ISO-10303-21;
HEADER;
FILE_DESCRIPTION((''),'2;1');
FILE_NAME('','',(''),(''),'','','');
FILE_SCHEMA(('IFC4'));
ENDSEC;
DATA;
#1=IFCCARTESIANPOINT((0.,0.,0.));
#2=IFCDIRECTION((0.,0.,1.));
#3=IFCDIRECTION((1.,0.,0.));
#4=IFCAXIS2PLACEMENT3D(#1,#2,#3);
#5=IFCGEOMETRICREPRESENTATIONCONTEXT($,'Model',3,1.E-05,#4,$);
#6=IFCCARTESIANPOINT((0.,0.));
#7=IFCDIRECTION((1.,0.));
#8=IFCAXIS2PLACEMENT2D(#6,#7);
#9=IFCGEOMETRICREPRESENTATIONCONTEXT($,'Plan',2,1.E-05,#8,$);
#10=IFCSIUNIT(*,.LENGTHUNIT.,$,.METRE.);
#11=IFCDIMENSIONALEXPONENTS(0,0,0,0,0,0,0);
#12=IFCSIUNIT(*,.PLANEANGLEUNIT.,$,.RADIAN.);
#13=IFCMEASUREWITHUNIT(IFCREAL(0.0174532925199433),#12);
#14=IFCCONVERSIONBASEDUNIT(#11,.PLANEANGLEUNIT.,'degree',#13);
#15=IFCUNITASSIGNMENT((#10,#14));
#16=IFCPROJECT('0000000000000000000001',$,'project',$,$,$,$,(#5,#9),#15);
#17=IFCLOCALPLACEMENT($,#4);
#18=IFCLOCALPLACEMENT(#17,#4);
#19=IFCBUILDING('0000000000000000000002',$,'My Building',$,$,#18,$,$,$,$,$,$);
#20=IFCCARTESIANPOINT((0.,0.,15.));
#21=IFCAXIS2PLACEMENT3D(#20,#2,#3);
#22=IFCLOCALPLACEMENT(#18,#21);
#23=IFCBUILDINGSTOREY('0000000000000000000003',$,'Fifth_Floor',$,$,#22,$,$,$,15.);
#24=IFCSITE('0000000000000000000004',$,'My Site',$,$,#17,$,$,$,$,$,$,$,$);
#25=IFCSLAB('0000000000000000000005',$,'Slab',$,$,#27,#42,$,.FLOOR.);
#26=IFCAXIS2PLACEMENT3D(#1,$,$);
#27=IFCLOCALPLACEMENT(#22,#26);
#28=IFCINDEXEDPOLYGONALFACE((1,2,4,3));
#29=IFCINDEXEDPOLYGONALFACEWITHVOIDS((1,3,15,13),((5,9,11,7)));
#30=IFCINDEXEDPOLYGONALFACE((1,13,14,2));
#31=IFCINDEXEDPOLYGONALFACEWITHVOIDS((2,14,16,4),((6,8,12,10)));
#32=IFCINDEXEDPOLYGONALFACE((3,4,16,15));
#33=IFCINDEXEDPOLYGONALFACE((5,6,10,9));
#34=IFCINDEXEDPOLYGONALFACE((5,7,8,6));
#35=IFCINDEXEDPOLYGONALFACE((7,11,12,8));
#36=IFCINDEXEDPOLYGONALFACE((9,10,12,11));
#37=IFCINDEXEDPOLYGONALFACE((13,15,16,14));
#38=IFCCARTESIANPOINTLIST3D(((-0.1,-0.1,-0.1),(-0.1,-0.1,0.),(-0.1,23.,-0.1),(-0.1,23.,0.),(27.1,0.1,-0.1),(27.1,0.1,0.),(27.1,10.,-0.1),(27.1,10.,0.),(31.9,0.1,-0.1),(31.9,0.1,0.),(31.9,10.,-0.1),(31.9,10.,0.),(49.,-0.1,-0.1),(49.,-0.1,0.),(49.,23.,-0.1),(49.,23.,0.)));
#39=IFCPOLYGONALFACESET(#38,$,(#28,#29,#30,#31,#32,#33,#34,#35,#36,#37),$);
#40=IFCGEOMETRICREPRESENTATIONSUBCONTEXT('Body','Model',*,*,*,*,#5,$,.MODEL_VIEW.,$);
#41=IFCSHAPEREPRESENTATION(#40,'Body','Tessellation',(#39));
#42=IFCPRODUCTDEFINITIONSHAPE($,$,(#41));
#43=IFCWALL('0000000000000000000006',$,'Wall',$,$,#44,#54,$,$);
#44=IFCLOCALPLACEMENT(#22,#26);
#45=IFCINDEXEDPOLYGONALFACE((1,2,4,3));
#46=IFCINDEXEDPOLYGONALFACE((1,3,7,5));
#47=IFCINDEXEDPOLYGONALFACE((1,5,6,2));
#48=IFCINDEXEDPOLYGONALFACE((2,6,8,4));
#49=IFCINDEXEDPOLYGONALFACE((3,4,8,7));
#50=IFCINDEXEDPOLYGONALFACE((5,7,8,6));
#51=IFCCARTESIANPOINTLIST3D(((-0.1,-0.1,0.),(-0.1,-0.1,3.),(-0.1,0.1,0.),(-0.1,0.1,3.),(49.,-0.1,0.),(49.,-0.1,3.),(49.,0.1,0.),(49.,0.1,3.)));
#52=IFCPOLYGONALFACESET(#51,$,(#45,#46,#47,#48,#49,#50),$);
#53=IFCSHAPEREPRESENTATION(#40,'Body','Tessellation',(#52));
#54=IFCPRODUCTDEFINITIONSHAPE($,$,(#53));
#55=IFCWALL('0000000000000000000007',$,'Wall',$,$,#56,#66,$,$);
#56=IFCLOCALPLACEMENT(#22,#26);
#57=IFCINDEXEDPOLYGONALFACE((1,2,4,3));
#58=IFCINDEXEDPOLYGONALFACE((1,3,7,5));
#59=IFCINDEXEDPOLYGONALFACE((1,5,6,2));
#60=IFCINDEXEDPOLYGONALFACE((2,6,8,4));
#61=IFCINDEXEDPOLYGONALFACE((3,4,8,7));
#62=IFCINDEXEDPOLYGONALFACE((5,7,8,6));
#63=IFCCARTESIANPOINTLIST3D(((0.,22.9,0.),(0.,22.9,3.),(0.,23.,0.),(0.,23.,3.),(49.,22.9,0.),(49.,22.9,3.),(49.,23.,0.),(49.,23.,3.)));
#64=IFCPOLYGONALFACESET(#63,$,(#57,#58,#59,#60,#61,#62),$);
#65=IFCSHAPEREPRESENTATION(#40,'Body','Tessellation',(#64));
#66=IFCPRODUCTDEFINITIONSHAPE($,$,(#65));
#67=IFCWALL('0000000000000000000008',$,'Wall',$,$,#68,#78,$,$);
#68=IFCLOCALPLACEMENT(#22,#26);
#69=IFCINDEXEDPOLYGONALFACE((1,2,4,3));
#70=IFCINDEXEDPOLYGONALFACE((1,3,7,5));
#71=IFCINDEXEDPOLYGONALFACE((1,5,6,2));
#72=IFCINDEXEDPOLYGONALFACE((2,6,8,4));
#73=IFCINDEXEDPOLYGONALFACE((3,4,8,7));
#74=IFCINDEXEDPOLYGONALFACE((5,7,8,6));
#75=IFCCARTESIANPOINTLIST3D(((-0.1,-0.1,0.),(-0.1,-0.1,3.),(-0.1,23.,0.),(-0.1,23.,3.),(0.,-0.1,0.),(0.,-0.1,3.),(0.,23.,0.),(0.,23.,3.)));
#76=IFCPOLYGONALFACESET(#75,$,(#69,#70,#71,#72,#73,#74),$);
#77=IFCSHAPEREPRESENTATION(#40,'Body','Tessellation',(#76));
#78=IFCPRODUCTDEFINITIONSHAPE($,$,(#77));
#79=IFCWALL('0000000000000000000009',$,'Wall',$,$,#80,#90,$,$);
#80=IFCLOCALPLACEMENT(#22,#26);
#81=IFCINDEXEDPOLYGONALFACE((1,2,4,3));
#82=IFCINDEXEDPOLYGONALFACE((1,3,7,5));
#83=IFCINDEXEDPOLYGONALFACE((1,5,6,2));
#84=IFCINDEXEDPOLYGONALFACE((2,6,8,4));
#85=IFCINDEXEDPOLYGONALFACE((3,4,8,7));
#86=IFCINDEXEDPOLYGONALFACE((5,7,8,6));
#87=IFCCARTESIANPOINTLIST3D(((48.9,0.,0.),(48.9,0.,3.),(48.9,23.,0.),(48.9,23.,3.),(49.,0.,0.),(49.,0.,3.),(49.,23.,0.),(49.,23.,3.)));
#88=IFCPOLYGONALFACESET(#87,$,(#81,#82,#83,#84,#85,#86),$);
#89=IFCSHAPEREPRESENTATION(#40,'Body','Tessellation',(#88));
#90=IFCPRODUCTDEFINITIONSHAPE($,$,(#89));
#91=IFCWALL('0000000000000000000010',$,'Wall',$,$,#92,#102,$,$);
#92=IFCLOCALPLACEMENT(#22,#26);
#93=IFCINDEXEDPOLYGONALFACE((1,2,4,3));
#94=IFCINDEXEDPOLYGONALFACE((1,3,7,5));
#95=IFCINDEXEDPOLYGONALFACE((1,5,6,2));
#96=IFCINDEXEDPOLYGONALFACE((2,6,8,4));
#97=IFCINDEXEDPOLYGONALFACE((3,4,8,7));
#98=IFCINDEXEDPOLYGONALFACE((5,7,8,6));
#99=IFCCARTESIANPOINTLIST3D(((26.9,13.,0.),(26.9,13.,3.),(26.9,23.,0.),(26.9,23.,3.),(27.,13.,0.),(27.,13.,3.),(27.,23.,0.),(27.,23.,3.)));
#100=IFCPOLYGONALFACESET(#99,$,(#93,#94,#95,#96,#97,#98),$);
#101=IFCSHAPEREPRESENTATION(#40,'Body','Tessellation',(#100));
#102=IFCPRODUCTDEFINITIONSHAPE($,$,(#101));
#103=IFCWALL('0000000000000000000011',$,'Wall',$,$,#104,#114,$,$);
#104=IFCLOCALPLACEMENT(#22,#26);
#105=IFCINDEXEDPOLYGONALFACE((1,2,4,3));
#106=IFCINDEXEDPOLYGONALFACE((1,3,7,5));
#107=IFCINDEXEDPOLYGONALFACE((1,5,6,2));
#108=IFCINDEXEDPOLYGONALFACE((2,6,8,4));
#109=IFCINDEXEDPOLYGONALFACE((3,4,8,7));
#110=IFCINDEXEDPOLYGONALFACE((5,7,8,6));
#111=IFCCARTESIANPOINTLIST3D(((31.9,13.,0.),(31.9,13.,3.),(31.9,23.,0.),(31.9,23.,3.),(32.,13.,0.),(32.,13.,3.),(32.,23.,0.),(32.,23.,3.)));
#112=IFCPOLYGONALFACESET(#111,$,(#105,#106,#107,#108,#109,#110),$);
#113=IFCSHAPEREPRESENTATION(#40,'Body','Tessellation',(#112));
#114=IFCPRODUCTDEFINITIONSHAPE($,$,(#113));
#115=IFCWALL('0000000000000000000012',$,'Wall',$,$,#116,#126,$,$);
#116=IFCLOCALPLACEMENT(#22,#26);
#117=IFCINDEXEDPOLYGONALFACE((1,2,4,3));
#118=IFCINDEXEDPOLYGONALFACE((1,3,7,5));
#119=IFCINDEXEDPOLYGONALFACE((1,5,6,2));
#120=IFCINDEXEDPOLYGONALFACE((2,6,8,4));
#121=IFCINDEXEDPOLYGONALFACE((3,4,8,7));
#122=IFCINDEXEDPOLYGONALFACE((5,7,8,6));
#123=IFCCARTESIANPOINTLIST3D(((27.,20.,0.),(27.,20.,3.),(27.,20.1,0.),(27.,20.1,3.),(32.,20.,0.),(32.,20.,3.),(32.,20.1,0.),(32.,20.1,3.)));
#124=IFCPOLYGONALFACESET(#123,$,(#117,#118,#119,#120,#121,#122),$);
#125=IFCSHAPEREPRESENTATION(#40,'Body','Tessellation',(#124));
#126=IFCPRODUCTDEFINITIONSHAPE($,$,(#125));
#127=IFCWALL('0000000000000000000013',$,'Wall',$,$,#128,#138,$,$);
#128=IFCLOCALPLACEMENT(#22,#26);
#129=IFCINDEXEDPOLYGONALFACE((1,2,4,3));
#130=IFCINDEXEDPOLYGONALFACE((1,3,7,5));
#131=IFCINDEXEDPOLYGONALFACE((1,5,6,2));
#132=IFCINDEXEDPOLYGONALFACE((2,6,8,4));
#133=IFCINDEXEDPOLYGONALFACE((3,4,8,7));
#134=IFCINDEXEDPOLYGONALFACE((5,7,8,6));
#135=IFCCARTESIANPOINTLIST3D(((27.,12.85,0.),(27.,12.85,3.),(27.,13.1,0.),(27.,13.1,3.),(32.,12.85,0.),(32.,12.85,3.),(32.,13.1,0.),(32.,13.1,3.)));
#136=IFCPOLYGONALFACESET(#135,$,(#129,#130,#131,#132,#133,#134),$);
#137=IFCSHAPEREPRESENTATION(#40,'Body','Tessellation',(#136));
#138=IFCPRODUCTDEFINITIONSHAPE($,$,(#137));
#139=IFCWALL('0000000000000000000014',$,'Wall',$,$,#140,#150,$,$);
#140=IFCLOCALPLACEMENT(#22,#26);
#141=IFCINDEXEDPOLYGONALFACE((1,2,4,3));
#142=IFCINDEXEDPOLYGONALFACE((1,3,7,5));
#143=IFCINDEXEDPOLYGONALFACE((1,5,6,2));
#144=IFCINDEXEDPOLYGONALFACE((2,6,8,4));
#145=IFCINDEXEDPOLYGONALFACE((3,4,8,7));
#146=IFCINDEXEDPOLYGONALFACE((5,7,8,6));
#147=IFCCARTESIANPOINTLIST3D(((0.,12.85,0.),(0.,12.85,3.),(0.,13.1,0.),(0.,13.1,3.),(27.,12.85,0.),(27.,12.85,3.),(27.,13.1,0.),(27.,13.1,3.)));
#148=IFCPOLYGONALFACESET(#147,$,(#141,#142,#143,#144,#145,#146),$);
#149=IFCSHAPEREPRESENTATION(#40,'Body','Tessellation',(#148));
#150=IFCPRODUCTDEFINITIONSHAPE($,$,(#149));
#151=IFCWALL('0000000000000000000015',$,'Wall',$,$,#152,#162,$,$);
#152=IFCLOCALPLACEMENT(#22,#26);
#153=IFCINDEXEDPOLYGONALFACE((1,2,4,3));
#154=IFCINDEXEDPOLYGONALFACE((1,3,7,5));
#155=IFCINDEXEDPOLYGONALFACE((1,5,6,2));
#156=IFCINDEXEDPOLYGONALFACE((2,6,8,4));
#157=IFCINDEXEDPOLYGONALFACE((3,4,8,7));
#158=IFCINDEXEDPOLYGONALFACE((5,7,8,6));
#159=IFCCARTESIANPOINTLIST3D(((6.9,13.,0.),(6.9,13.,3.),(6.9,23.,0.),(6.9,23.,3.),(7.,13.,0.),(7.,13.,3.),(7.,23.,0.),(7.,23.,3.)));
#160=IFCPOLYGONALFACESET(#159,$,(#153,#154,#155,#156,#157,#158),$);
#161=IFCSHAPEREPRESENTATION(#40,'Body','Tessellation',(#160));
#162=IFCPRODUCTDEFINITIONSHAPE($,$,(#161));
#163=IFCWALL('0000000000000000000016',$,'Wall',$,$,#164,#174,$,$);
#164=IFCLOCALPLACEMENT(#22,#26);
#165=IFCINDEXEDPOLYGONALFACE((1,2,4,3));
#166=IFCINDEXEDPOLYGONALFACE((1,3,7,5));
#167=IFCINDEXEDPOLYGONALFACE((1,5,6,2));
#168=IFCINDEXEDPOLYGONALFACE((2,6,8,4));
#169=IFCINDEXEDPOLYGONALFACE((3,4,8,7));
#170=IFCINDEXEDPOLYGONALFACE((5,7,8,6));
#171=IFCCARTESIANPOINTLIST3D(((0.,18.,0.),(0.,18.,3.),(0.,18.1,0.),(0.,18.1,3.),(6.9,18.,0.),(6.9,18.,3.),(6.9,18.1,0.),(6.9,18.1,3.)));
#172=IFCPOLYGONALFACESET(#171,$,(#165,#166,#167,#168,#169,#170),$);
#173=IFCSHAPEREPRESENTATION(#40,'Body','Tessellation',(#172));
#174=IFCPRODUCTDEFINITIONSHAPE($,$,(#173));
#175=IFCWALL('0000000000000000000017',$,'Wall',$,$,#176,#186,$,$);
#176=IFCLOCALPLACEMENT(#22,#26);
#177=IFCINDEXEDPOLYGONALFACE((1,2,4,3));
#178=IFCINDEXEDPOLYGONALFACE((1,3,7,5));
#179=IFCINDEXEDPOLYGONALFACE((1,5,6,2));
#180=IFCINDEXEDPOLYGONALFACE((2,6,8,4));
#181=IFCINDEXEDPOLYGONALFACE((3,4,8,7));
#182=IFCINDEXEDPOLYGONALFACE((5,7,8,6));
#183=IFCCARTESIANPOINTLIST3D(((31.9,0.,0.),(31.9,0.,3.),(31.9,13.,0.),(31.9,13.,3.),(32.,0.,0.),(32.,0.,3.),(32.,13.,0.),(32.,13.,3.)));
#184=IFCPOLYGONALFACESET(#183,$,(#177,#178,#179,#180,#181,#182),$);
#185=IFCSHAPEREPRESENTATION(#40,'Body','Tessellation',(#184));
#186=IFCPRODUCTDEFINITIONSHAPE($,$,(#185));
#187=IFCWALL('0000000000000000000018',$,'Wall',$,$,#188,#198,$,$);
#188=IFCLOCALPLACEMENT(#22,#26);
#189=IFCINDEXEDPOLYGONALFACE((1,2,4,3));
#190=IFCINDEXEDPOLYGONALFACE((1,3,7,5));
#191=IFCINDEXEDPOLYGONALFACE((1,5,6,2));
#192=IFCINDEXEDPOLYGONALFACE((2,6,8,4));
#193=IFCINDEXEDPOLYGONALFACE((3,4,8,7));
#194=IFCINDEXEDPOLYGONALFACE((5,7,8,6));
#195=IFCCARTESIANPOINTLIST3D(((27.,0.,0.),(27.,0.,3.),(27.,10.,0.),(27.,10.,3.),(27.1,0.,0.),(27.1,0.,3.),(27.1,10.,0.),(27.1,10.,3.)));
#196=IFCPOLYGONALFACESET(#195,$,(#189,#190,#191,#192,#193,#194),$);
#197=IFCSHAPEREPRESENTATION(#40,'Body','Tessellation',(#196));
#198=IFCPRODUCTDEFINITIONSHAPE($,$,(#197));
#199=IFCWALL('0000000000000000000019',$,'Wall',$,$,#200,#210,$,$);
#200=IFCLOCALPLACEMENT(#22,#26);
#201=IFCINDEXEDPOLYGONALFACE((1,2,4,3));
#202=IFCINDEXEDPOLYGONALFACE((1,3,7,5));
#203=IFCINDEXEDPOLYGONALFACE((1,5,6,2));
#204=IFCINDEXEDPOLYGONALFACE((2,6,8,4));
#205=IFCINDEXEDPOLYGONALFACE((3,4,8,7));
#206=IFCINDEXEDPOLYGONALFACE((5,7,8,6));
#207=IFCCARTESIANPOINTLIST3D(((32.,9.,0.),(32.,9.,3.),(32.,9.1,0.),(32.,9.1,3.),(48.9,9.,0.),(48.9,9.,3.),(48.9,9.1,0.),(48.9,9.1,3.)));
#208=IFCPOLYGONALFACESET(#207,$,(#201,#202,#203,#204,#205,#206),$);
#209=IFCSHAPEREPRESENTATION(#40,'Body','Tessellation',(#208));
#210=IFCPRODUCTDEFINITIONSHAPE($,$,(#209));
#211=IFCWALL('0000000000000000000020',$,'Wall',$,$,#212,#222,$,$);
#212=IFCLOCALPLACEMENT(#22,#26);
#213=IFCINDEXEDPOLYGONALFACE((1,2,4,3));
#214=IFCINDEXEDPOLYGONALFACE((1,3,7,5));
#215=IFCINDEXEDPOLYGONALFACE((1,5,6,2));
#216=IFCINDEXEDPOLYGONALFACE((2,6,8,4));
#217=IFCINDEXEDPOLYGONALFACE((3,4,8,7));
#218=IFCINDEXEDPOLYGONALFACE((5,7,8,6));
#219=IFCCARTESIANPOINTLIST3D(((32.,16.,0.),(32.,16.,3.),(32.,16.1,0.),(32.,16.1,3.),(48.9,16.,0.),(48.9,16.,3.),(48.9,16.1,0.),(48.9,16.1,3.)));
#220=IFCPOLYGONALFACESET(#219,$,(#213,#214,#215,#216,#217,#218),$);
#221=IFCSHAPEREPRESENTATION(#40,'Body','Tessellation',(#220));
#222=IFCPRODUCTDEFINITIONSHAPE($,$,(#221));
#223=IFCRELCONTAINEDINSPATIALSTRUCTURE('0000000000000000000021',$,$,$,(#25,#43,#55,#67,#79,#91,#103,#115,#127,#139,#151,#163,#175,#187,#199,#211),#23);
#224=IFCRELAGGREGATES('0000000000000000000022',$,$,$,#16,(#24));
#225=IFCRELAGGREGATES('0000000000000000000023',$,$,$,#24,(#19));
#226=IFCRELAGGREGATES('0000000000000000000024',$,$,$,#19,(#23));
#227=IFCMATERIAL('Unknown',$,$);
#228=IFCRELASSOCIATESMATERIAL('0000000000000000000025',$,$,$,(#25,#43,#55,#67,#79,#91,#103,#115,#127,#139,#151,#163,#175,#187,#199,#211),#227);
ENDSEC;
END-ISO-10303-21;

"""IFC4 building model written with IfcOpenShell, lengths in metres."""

from ifc_helpers import new_model, entity, si_unit, converted_unit, frame, frame_2d, origin, origin_with_axes, origin_2d_with_axis, place, context, subcontext, project, spatial, rectangle, extrude, material, element, save


model = new_model("IFC4")

# Units and contexts
model_context = context("Model", 3, precision=1e-05, world=origin_with_axes())
plan_context = context("Plan", 2, precision=1e-05, world=origin_2d_with_axis())
body_context = subcontext(model_context, "Body", "Model", "MODEL_VIEW")
ifc_project = project(units=[si_unit("LENGTHUNIT", "METRE"), converted_unit("PLANEANGLEUNIT", "degree", entity("IfcReal", 0.0174532925199433), si_unit("PLANEANGLEUNIT", "RADIAN"), dimensions=[0, 0, 0, 0, 0, 0, 0])], contexts=[model_context, plan_context])

# Site, building, storey
site_placement = place(None, origin_with_axes())
site = spatial("IfcSite", under=ifc_project, at=site_placement, Name="My Site")
building_placement = place(site_placement, origin_with_axes())
building = spatial("IfcBuilding", under=site, at=building_placement, Name="My Building")
storey_placement = place(building_placement, frame((0.0, 0.0, 15.0), z_axis=(0.0, 0.0, 1.0), x_axis=(1.0, 0.0, 0.0)))
storey = spatial("IfcBuildingStorey", under=building, at=storey_placement, Name="Fifth_Floor", Elevation=15.0)

# Slab, opening
ifc_material = material(Name="Unknown")
slab_placement = place(storey_placement, origin_with_axes())
slab = element("IfcSlab", 1, at=slab_placement, inside=storey, material=ifc_material, Name="Slab", PredefinedType="FLOOR", context=body_context, shape_type="SweptSolid", body=[
    extrude(rectangle(XDim=49.1, YDim=23.1, at=frame_2d((24.45, 11.45))), frame((0.0, 0.0, -0.1)), (0.0, 0.0, 1.0), 0.1),
])
opening_placement = place(slab_placement, origin_with_axes())
element("IfcOpeningElement", 2, at=opening_placement, cuts=slab, context=body_context, shape_type="SweptSolid", body=[
    extrude(rectangle(XDim=4.8, YDim=9.9, at=frame_2d((29.5, 5.05))), frame((0.0, 0.0, -0.25)), (0.0, 0.0, 1.0), 0.4),
])

# Walls
wall_1_placement = place(storey_placement, origin_with_axes())
element("IfcWall", 3, at=wall_1_placement, inside=storey, material=ifc_material, Name="Wall", context=body_context, shape_type="SweptSolid", body=[
    extrude(rectangle(XDim=49.1, YDim=0.2, at=frame_2d((24.45, 0.0))), origin(), (0.0, 0.0, 1.0), 3.0),
])
wall_2_placement = place(storey_placement, origin_with_axes())
element("IfcWall", 4, at=wall_2_placement, inside=storey, material=ifc_material, Name="Wall", context=body_context, shape_type="SweptSolid", body=[
    extrude(rectangle(XDim=49.0, YDim=0.1, at=frame_2d((24.5, 22.95))), origin(), (0.0, 0.0, 1.0), 3.0),
])
wall_3_placement = place(storey_placement, origin_with_axes())
element("IfcWall", 5, at=wall_3_placement, inside=storey, material=ifc_material, Name="Wall", context=body_context, shape_type="SweptSolid", body=[
    extrude(rectangle(XDim=0.1, YDim=23.1, at=frame_2d((-0.05, 11.45))), origin(), (0.0, 0.0, 1.0), 3.0),
])
wall_4_placement = place(storey_placement, origin_with_axes())
element("IfcWall", 6, at=wall_4_placement, inside=storey, material=ifc_material, Name="Wall", context=body_context, shape_type="SweptSolid", body=[
    extrude(rectangle(XDim=0.1, YDim=23.0, at=frame_2d((48.95, 11.5))), origin(), (0.0, 0.0, 1.0), 3.0),
])
wall_5_placement = place(storey_placement, origin_with_axes())
element("IfcWall", 7, at=wall_5_placement, inside=storey, material=ifc_material, Name="Wall", context=body_context, shape_type="SweptSolid", body=[
    extrude(rectangle(XDim=0.1, YDim=10.0, at=frame_2d((26.95, 18.0))), origin(), (0.0, 0.0, 1.0), 3.0),
])
wall_6_placement = place(storey_placement, origin_with_axes())
element("IfcWall", 8, at=wall_6_placement, inside=storey, material=ifc_material, Name="Wall", context=body_context, shape_type="SweptSolid", body=[
    extrude(rectangle(XDim=0.1, YDim=10.0, at=frame_2d((31.95, 18.0))), origin(), (0.0, 0.0, 1.0), 3.0),
])
wall_7_placement = place(storey_placement, origin_with_axes())
element("IfcWall", 9, at=wall_7_placement, inside=storey, material=ifc_material, Name="Wall", context=body_context, shape_type="SweptSolid", body=[
    extrude(rectangle(XDim=5.0, YDim=0.1, at=frame_2d((29.5, 20.05))), origin(), (0.0, 0.0, 1.0), 3.0),
])
wall_8_placement = place(storey_placement, origin_with_axes())
element("IfcWall", 10, at=wall_8_placement, inside=storey, material=ifc_material, Name="Wall", context=body_context, shape_type="SweptSolid", body=[
    extrude(rectangle(XDim=5.0, YDim=0.25, at=frame_2d((29.5, 12.975))), origin(), (0.0, 0.0, 1.0), 3.0),
])
wall_9_placement = place(storey_placement, origin_with_axes())
element("IfcWall", 11, at=wall_9_placement, inside=storey, material=ifc_material, Name="Wall", context=body_context, shape_type="SweptSolid", body=[
    extrude(rectangle(XDim=27.0, YDim=0.25, at=frame_2d((13.5, 12.975))), origin(), (0.0, 0.0, 1.0), 3.0),
])
wall_10_placement = place(storey_placement, origin_with_axes())
element("IfcWall", 12, at=wall_10_placement, inside=storey, material=ifc_material, Name="Wall", context=body_context, shape_type="SweptSolid", body=[
    extrude(rectangle(XDim=0.1, YDim=10.0, at=frame_2d((6.95, 18.0))), origin(), (0.0, 0.0, 1.0), 3.0),
])
wall_11_placement = place(storey_placement, origin_with_axes())
element("IfcWall", 13, at=wall_11_placement, inside=storey, material=ifc_material, Name="Wall", context=body_context, shape_type="SweptSolid", body=[
    extrude(rectangle(XDim=6.9, YDim=0.1, at=frame_2d((3.45, 18.05))), origin(), (0.0, 0.0, 1.0), 3.0),
])
wall_12_placement = place(storey_placement, origin_with_axes())
element("IfcWall", 14, at=wall_12_placement, inside=storey, material=ifc_material, Name="Wall", context=body_context, shape_type="SweptSolid", body=[
    extrude(rectangle(XDim=0.1, YDim=13.0, at=frame_2d((31.95, 6.5))), origin(), (0.0, 0.0, 1.0), 3.0),
])
wall_13_placement = place(storey_placement, origin_with_axes())
element("IfcWall", 15, at=wall_13_placement, inside=storey, material=ifc_material, Name="Wall", context=body_context, shape_type="SweptSolid", body=[
    extrude(rectangle(XDim=0.1, YDim=10.0, at=frame_2d((27.05, 5.0))), origin(), (0.0, 0.0, 1.0), 3.0),
])
wall_14_placement = place(storey_placement, origin_with_axes())
element("IfcWall", 16, at=wall_14_placement, inside=storey, material=ifc_material, Name="Wall", context=body_context, shape_type="SweptSolid", body=[
    extrude(rectangle(XDim=16.9, YDim=0.1, at=frame_2d((40.45, 9.05))), origin(), (0.0, 0.0, 1.0), 3.0),
])
wall_15_placement = place(storey_placement, origin_with_axes())
element("IfcWall", 17, at=wall_15_placement, inside=storey, material=ifc_material, Name="Wall", context=body_context, shape_type="SweptSolid", body=[
    extrude(rectangle(XDim=16.9, YDim=0.1, at=frame_2d((40.45, 16.05))), origin(), (0.0, 0.0, 1.0), 3.0),
])

save(model, "model.ifc")
